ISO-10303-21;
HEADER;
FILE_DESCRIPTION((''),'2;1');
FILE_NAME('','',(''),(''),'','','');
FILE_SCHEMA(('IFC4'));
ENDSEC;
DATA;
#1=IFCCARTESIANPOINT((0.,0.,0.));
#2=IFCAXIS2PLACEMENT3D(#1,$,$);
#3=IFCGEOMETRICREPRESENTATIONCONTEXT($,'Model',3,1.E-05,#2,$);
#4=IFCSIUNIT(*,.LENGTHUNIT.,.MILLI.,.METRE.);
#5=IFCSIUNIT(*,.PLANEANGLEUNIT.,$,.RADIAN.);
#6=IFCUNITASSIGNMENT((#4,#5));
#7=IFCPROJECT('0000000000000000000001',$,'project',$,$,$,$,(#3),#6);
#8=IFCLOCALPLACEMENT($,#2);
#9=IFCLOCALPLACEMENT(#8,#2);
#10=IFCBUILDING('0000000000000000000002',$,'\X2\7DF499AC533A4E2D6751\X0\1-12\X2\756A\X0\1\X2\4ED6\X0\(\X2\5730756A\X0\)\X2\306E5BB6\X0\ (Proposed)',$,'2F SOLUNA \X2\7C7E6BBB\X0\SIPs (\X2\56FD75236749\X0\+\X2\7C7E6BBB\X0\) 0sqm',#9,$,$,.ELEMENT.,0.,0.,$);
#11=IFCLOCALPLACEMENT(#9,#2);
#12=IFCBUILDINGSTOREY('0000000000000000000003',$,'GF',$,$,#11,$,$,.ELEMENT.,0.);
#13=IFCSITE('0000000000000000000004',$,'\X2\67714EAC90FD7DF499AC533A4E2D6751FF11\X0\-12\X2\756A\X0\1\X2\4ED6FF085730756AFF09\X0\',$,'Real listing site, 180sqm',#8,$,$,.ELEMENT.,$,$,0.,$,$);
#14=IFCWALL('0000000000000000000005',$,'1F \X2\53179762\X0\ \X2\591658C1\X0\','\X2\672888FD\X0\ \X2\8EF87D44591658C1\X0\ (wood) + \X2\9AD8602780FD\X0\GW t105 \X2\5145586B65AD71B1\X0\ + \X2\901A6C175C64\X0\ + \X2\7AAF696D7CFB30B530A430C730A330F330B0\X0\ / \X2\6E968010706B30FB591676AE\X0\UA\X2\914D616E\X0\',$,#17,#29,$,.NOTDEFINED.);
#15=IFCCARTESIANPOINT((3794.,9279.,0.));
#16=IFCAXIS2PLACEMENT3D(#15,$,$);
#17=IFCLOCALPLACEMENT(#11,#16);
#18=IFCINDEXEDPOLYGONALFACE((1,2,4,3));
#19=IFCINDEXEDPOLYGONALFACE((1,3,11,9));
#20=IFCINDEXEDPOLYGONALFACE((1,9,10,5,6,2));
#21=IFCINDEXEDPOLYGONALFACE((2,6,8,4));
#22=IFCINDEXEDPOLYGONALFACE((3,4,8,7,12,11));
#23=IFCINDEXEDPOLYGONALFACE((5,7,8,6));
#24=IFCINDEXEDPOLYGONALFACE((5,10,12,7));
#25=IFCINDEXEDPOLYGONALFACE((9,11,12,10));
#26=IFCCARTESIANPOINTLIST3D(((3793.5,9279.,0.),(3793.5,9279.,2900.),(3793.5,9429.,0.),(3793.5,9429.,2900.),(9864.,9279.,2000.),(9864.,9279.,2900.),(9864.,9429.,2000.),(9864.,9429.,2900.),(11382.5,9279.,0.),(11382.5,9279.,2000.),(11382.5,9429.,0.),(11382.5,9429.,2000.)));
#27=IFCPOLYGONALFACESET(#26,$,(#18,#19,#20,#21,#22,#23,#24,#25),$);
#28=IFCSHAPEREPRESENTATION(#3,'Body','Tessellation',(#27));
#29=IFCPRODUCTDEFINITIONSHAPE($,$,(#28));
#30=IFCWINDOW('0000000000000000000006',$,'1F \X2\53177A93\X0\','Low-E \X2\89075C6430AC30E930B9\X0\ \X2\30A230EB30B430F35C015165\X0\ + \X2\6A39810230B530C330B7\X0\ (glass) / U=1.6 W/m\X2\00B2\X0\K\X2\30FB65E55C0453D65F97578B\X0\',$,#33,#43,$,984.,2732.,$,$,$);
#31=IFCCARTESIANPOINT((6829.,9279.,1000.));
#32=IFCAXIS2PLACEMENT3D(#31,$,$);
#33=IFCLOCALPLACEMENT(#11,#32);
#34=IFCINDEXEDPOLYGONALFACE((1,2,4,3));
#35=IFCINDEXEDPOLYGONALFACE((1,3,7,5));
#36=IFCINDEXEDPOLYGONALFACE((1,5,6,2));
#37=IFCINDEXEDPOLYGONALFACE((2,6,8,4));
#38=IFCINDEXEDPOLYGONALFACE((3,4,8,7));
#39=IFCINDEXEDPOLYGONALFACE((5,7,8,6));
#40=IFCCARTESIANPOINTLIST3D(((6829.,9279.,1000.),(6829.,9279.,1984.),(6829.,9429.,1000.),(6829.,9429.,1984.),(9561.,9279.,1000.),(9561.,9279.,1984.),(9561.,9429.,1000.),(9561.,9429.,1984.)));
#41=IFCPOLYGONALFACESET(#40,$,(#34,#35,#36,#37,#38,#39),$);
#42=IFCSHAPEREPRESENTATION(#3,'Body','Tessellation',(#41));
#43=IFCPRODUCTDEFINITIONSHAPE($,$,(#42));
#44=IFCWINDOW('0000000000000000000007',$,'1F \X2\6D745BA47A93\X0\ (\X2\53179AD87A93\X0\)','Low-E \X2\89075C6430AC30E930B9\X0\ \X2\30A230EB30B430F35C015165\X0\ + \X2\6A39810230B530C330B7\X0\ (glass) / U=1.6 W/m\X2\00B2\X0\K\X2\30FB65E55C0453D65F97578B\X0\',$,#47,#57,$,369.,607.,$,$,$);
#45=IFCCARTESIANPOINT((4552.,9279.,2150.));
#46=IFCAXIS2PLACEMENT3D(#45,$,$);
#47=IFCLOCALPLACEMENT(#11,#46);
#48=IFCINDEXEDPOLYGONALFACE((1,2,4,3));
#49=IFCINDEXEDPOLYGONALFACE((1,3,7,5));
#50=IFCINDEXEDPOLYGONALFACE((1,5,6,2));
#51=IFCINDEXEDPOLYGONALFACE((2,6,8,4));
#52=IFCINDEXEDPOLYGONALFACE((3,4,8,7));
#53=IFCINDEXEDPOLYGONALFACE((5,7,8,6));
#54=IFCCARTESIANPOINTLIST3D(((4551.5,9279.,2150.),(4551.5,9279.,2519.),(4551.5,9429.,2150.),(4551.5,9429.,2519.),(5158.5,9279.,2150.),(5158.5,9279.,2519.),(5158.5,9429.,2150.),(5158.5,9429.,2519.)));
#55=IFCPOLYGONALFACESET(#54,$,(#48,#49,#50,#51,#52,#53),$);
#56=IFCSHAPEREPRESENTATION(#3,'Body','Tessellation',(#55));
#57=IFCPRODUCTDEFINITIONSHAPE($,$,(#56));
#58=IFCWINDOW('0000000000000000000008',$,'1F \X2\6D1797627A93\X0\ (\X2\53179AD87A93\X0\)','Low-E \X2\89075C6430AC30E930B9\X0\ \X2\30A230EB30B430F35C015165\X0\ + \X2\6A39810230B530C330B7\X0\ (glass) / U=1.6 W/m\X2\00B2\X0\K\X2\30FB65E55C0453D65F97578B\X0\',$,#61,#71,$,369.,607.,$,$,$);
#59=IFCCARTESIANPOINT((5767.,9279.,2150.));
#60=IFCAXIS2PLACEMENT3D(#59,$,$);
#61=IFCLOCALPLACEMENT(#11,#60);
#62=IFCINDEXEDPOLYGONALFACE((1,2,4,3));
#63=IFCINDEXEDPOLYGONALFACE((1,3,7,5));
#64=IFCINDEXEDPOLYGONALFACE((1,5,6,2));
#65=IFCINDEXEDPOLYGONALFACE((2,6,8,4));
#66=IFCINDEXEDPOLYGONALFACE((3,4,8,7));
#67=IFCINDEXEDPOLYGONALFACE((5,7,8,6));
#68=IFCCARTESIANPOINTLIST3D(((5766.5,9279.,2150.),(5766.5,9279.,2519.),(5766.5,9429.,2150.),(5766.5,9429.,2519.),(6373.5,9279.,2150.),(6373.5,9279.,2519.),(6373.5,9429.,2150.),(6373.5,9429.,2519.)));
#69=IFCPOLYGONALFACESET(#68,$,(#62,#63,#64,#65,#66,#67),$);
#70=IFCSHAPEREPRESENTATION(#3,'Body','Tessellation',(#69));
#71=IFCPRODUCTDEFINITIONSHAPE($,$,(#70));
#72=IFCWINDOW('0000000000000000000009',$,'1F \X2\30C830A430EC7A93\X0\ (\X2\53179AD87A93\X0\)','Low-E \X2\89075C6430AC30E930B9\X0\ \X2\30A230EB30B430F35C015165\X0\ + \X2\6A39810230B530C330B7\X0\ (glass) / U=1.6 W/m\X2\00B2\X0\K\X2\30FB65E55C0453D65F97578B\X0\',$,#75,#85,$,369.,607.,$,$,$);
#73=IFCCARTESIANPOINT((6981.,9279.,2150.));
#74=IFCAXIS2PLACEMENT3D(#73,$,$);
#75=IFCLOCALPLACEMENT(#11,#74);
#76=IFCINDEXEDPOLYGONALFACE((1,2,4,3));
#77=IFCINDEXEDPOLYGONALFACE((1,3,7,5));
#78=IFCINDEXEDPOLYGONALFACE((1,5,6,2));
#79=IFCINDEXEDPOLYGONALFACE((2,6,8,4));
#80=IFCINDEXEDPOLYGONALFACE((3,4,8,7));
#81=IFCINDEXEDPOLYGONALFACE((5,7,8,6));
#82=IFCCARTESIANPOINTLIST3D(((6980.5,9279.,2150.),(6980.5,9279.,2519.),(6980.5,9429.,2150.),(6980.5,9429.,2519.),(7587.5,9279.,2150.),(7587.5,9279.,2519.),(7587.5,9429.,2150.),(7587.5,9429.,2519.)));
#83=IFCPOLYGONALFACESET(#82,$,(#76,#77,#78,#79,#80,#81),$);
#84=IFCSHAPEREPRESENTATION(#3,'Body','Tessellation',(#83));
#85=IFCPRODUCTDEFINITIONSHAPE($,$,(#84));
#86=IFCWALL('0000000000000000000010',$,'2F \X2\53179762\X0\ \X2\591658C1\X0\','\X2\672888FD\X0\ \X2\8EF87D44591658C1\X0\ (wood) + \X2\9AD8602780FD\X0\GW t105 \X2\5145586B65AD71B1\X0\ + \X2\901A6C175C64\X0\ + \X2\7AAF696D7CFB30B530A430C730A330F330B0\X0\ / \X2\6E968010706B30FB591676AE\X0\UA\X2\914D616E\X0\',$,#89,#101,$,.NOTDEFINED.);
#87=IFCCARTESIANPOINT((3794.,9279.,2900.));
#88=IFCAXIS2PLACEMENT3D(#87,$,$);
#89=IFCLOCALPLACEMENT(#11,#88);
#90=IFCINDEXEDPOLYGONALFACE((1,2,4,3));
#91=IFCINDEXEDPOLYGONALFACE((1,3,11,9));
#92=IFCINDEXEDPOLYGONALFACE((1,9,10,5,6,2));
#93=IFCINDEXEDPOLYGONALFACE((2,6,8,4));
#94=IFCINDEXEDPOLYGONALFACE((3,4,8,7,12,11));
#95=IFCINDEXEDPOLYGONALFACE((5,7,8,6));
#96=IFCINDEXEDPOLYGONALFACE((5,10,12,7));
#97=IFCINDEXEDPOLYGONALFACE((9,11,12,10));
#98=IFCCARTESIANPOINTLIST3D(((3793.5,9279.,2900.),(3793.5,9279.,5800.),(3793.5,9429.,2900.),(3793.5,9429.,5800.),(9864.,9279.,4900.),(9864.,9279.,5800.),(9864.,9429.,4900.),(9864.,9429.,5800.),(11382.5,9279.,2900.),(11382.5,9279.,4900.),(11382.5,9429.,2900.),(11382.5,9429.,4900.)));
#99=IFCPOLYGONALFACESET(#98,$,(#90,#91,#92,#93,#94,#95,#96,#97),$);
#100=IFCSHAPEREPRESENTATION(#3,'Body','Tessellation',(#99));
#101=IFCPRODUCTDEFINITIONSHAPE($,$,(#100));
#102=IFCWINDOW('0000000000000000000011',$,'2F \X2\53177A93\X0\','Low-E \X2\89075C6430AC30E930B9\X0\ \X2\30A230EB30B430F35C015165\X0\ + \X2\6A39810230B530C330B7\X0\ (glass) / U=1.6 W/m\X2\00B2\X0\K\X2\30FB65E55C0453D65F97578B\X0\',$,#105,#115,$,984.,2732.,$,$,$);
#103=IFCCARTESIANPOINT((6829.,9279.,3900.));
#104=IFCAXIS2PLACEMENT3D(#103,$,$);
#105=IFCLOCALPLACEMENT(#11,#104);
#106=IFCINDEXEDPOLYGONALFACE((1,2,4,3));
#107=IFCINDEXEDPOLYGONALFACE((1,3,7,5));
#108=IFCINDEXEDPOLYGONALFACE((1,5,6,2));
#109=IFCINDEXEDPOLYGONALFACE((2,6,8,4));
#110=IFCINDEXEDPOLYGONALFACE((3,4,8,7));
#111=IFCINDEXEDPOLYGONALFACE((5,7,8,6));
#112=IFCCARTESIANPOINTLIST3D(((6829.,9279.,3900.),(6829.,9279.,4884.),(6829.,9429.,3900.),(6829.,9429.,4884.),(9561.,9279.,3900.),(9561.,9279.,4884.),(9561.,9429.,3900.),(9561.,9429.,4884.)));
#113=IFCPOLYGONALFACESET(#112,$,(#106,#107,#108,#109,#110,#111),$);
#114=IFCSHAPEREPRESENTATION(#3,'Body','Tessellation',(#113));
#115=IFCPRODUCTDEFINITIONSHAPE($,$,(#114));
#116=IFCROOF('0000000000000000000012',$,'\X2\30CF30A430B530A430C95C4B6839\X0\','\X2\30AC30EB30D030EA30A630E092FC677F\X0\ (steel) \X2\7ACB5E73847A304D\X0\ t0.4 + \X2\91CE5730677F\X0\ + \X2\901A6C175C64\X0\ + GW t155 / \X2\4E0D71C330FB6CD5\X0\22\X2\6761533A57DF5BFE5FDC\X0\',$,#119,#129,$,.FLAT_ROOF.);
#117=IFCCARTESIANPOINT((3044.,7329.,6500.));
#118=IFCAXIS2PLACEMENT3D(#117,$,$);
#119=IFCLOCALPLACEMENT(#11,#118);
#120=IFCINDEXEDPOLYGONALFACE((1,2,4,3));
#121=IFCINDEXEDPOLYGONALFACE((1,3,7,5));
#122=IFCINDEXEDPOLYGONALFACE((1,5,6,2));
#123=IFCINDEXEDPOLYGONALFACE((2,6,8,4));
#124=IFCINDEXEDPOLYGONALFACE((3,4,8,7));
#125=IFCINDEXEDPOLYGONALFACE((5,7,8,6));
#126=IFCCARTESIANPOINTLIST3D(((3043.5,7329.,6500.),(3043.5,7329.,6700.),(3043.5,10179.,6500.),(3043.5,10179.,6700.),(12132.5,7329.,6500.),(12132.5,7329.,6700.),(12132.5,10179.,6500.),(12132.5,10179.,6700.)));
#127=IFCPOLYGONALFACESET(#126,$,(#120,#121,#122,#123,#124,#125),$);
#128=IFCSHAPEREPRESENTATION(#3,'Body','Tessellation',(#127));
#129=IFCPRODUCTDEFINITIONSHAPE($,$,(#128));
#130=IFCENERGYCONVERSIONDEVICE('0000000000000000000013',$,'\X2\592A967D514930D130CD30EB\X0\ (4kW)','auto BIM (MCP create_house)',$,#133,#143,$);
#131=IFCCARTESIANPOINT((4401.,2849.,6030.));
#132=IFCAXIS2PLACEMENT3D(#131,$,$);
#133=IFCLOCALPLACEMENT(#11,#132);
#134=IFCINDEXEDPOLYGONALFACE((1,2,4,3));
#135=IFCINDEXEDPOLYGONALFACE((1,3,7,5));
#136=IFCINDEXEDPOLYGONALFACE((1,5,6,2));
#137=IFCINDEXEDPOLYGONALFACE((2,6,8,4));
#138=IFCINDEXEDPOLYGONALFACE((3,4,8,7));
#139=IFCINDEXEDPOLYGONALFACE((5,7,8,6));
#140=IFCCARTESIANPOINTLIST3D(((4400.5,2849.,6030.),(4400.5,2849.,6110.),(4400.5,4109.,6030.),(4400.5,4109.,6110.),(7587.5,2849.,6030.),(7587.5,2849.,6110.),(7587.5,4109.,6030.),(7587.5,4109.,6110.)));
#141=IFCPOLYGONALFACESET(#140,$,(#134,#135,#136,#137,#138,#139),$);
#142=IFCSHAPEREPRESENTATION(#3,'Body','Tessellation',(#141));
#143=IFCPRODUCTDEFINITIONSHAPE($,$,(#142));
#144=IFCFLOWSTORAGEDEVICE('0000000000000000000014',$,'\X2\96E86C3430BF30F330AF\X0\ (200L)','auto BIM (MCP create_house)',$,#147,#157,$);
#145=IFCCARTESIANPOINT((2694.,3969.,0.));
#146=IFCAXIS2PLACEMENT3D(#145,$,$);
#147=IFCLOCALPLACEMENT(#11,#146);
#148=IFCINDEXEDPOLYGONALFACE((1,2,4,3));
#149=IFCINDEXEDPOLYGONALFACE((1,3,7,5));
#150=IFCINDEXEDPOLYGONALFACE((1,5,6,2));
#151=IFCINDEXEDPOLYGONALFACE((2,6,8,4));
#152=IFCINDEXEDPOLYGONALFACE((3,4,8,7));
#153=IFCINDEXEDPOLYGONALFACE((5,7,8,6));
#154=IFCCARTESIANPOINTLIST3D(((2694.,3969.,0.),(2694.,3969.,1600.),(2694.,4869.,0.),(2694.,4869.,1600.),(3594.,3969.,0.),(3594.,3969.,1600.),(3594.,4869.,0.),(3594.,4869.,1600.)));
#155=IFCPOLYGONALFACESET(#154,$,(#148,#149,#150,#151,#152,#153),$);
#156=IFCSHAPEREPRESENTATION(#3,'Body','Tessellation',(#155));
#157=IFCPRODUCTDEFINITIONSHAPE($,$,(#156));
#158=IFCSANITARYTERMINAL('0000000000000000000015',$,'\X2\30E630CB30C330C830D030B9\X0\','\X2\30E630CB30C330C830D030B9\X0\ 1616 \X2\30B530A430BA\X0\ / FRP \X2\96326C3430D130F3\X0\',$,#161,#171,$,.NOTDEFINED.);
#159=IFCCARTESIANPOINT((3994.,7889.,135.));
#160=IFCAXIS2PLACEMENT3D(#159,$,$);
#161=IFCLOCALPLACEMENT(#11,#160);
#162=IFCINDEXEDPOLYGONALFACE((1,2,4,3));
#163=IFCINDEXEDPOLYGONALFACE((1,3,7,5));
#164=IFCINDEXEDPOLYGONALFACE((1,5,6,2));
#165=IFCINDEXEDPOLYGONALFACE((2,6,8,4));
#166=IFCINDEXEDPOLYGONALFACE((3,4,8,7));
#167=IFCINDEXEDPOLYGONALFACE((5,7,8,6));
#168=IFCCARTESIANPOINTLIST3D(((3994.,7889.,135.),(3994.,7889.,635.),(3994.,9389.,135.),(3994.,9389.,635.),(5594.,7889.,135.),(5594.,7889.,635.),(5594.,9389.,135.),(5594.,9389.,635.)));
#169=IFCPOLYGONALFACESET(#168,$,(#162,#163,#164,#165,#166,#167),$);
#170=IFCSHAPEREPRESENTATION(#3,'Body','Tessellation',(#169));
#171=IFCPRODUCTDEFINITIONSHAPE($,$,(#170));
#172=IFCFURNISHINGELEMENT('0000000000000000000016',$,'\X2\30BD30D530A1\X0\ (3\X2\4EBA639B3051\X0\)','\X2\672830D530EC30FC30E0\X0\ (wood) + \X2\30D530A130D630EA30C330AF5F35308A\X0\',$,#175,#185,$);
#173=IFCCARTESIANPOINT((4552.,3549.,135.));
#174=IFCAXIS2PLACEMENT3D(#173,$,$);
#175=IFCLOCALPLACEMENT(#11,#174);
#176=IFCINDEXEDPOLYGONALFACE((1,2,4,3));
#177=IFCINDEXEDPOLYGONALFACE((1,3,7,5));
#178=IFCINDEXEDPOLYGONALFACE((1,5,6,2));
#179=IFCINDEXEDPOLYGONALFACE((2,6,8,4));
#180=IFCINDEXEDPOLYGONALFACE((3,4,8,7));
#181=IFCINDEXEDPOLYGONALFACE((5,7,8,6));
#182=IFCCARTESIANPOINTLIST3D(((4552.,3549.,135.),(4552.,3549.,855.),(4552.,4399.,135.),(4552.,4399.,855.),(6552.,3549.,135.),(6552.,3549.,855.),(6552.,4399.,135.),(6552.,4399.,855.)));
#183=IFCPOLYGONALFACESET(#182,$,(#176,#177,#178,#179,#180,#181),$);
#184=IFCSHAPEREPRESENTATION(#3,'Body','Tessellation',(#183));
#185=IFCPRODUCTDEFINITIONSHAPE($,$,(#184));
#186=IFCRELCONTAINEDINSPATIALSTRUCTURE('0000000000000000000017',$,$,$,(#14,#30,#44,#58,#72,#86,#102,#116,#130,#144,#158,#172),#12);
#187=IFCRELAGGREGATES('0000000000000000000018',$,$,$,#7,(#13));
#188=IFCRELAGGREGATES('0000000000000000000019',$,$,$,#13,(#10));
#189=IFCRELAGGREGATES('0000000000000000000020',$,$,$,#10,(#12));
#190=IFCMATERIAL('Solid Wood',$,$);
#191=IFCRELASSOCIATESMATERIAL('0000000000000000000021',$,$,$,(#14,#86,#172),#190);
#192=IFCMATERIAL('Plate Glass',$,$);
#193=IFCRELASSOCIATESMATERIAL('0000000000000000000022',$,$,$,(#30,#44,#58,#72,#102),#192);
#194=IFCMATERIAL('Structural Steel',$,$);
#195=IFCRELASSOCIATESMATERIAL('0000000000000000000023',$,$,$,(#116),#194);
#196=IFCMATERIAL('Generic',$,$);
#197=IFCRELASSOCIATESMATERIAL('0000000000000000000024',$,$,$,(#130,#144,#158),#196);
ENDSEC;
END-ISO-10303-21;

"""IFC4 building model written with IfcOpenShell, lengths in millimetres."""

from ifc_helpers import new_model, si_unit, frame, frame_2d, origin, place, context, project, spatial, rectangle, extrude, material, element, fill, save


model = new_model("IFC4")

# Units and contexts
model_context = context("Model", 3, precision=1e-05, world=origin())
ifc_project = project(units=[si_unit("LENGTHUNIT", "METRE", prefix="MILLI"), si_unit("PLANEANGLEUNIT", "RADIAN")], contexts=[model_context])

# Site, building, storey
site_placement = place(None, origin())
site = spatial("IfcSite", under=ifc_project, at=site_placement, Name="東京都練馬区中村１-12番1他（地番）", ObjectType="Real listing site, 180sqm", CompositionType="ELEMENT", RefElevation=0.0)
building_placement = place(site_placement, origin())
building = spatial("IfcBuilding", under=site, at=building_placement, Name="練馬区中村1-12番1他(地番)の家 (Proposed)", ObjectType="2F SOLUNA 籾殻SIPs (国産杉+籾殻) 0sqm", CompositionType="ELEMENT", ElevationOfRefHeight=0.0, ElevationOfTerrain=0.0)
storey_placement = place(building_placement, origin())
storey = spatial("IfcBuildingStorey", under=building, at=storey_placement, Name="GF", CompositionType="ELEMENT", Elevation=0.0)

# Wall, openings, windows
ifc_material_1 = material(Name="Solid Wood")
wall_1_placement = place(storey_placement, frame((3794.0, 9279.0, 0.0)))
wall_1 = element("IfcWall", 1, at=wall_1_placement, inside=storey, material=ifc_material_1, Name="1F 北面 外壁", Description="木製 軸組外壁 (wood) + 高性能GW t105 充填断熱 + 通気層 + 窯業系サイディング / 準耐火・外皮UA配慮", PredefinedType="NOTDEFINED", context=model_context, shape_type="SweptSolid", body=[
    extrude(rectangle(XDim=7589.0, YDim=150.0, at=frame_2d((3794.0, 75.0))), frame((3794.0, 9279.0, 0.0)), (0.0, 0.0, 1.0), 2900.0),
])
opening_1_placement = place(storey_placement, frame((6829.0, 9279.0, 1000.0)))
opening_1 = element("IfcOpeningElement", 2, at=opening_1_placement, cuts=wall_1, PredefinedType="NOTDEFINED", context=model_context, shape_type="SweptSolid", body=[
    extrude(rectangle(XDim=2732.0, YDim=150.0, at=frame_2d((1366.0, 75.0))), frame((6829.0, 9279.0, 1000.0)), (0.0, 0.0, 1.0), 984.0),
])
opening_2_placement = place(storey_placement, frame((4552.0, 9279.0, 2150.0)))
opening_2 = element("IfcOpeningElement", 3, at=opening_2_placement, cuts=wall_1, PredefinedType="NOTDEFINED", context=model_context, shape_type="SweptSolid", body=[
    extrude(rectangle(XDim=607.0, YDim=150.0, at=frame_2d((303.0, 75.0))), frame((4552.0, 9279.0, 2150.0)), (0.0, 0.0, 1.0), 369.0),
])
opening_3_placement = place(storey_placement, frame((5767.0, 9279.0, 2150.0)))
opening_3 = element("IfcOpeningElement", 4, at=opening_3_placement, cuts=wall_1, PredefinedType="NOTDEFINED", context=model_context, shape_type="SweptSolid", body=[
    extrude(rectangle(XDim=607.0, YDim=150.0, at=frame_2d((303.0, 75.0))), frame((5767.0, 9279.0, 2150.0)), (0.0, 0.0, 1.0), 369.0),
])
opening_4_placement = place(storey_placement, frame((6981.0, 9279.0, 2150.0)))
opening_4 = element("IfcOpeningElement", 5, at=opening_4_placement, cuts=wall_1, PredefinedType="NOTDEFINED", context=model_context, shape_type="SweptSolid", body=[
    extrude(rectangle(XDim=607.0, YDim=150.0, at=frame_2d((303.0, 75.0))), frame((6981.0, 9279.0, 2150.0)), (0.0, 0.0, 1.0), 369.0),
])
ifc_material_2 = material(Name="Plate Glass")
window_1_placement = place(storey_placement, frame((6829.0, 9279.0, 1000.0)))
window_1 = element("IfcWindow", 6, at=window_1_placement, inside=storey, material=ifc_material_2, Name="1F 北窓", Description="Low-E 複層ガラス アルゴン封入 + 樹脂サッシ (glass) / U=1.6 W/m²K・日射取得型", OverallHeight=984.0, OverallWidth=2732.0, context=model_context, shape_type="SweptSolid", body=[
    extrude(rectangle(XDim=2732.0, YDim=150.0, at=frame_2d((1366.0, 75.0))), frame((6829.0, 9279.0, 1000.0)), (0.0, 0.0, 1.0), 984.0),
])
fill(opening_1, window_1)
window_2_placement = place(storey_placement, frame((4552.0, 9279.0, 2150.0)))
window_2 = element("IfcWindow", 7, at=window_2_placement, inside=storey, material=ifc_material_2, Name="1F 浴室窓 (北高窓)", Description="Low-E 複層ガラス アルゴン封入 + 樹脂サッシ (glass) / U=1.6 W/m²K・日射取得型", OverallHeight=369.0, OverallWidth=607.0, context=model_context, shape_type="SweptSolid", body=[
    extrude(rectangle(XDim=607.0, YDim=150.0, at=frame_2d((303.0, 75.0))), frame((4552.0, 9279.0, 2150.0)), (0.0, 0.0, 1.0), 369.0),
])
fill(opening_2, window_2)
window_3_placement = place(storey_placement, frame((5767.0, 9279.0, 2150.0)))
window_3 = element("IfcWindow", 8, at=window_3_placement, inside=storey, material=ifc_material_2, Name="1F 洗面窓 (北高窓)", Description="Low-E 複層ガラス アルゴン封入 + 樹脂サッシ (glass) / U=1.6 W/m²K・日射取得型", OverallHeight=369.0, OverallWidth=607.0, context=model_context, shape_type="SweptSolid", body=[
    extrude(rectangle(XDim=607.0, YDim=150.0, at=frame_2d((303.0, 75.0))), frame((5767.0, 9279.0, 2150.0)), (0.0, 0.0, 1.0), 369.0),
])
fill(opening_3, window_3)
window_4_placement = place(storey_placement, frame((6981.0, 9279.0, 2150.0)))
window_4 = element("IfcWindow", 9, at=window_4_placement, inside=storey, material=ifc_material_2, Name="1F トイレ窓 (北高窓)", Description="Low-E 複層ガラス アルゴン封入 + 樹脂サッシ (glass) / U=1.6 W/m²K・日射取得型", OverallHeight=369.0, OverallWidth=607.0, context=model_context, shape_type="SweptSolid", body=[
    extrude(rectangle(XDim=607.0, YDim=150.0, at=frame_2d((303.0, 75.0))), frame((6981.0, 9279.0, 2150.0)), (0.0, 0.0, 1.0), 369.0),
])
fill(opening_4, window_4)

# Wall, opening, window
wall_2_placement = place(storey_placement, frame((3794.0, 9279.0, 2900.0)))
wall_2 = element("IfcWall", 10, at=wall_2_placement, inside=storey, material=ifc_material_1, Name="2F 北面 外壁", Description="木製 軸組外壁 (wood) + 高性能GW t105 充填断熱 + 通気層 + 窯業系サイディング / 準耐火・外皮UA配慮", PredefinedType="NOTDEFINED", context=model_context, shape_type="SweptSolid", body=[
    extrude(rectangle(XDim=7589.0, YDim=150.0, at=frame_2d((3794.0, 75.0))), frame((3794.0, 9279.0, 2900.0)), (0.0, 0.0, 1.0), 2900.0),
])
opening_5_placement = place(storey_placement, frame((6829.0, 9279.0, 3900.0)))
opening_5 = element("IfcOpeningElement", 11, at=opening_5_placement, cuts=wall_2, PredefinedType="NOTDEFINED", context=model_context, shape_type="SweptSolid", body=[
    extrude(rectangle(XDim=2732.0, YDim=150.0, at=frame_2d((1366.0, 75.0))), frame((6829.0, 9279.0, 3900.0)), (0.0, 0.0, 1.0), 984.0),
])
window_5_placement = place(storey_placement, frame((6829.0, 9279.0, 3900.0)))
window_5 = element("IfcWindow", 12, at=window_5_placement, inside=storey, material=ifc_material_2, Name="2F 北窓", Description="Low-E 複層ガラス アルゴン封入 + 樹脂サッシ (glass) / U=1.6 W/m²K・日射取得型", OverallHeight=984.0, OverallWidth=2732.0, context=model_context, shape_type="SweptSolid", body=[
    extrude(rectangle(XDim=2732.0, YDim=150.0, at=frame_2d((1366.0, 75.0))), frame((6829.0, 9279.0, 3900.0)), (0.0, 0.0, 1.0), 984.0),
])
fill(opening_5, window_5)

# Roof
ifc_material_3 = material(Name="Structural Steel")
roof_placement = place(storey_placement, frame((3044.0, 7329.0, 6500.0)))
element("IfcRoof", 13, at=roof_placement, inside=storey, material=ifc_material_3, Name="ハイサイド屋根", Description="ガルバリウム鋼板 (steel) 立平葺き t0.4 + 野地板 + 通気層 + GW t155 / 不燃・法22条区域対応", PredefinedType="FLAT_ROOF", context=model_context, shape_type="SweptSolid", body=[
    extrude(rectangle(XDim=9089.0, YDim=2850.0, at=frame_2d((4544.0, 1425.0))), frame((3044.0, 7329.0, 6500.0)), (0.0, 0.0, 1.0), 200.0),
])

# Energy conversion device
ifc_material_4 = material(Name="Generic")
energy_conversion_device_placement = place(storey_placement, frame((4401.0, 2849.0, 6030.0)))
element("IfcEnergyConversionDevice", 14, at=energy_conversion_device_placement, inside=storey, material=ifc_material_4, Name="太陽光パネル (4kW)", Description="auto BIM (MCP create_house)", context=model_context, shape_type="SweptSolid", body=[
    extrude(rectangle(XDim=3187.0, YDim=1260.0, at=frame_2d((1593.0, 630.0))), frame((4401.0, 2849.0, 6030.0)), (0.0, 0.0, 1.0), 80.0),
])

# Flow storage device
flow_storage_device_placement = place(storey_placement, frame((2694.0, 3969.0, 0.0)))
element("IfcFlowStorageDevice", 15, at=flow_storage_device_placement, inside=storey, material=ifc_material_4, Name="雨水タンク (200L)", Description="auto BIM (MCP create_house)", context=model_context, shape_type="SweptSolid", body=[
    extrude(rectangle(XDim=900.0, YDim=900.0, at=frame_2d((450.0, 450.0))), frame((2694.0, 3969.0, 0.0)), (0.0, 0.0, 1.0), 1600.0),
])

# Sanitary terminal
sanitary_terminal_placement = place(storey_placement, frame((3994.0, 7889.0, 135.0)))
element("IfcSanitaryTerminal", 16, at=sanitary_terminal_placement, inside=storey, material=ifc_material_4, Name="ユニットバス", Description="ユニットバス 1616 サイズ / FRP 防水パン", PredefinedType="NOTDEFINED", context=model_context, shape_type="SweptSolid", body=[
    extrude(rectangle(XDim=1600.0, YDim=1500.0, at=frame_2d((800.0, 750.0))), frame((3994.0, 7889.0, 135.0)), (0.0, 0.0, 1.0), 500.0),
])

# Furnishing element
furnishing_1_placement = place(storey_placement, frame((4552.0, 3549.0, 135.0)))
element("IfcFurnishingElement", 17, at=furnishing_1_placement, inside=storey, material=ifc_material_1, Name="ソファ (3人掛け)", Description="木フレーム (wood) + ファブリック張り", context=model_context, shape_type="SweptSolid", body=[
    extrude(rectangle(XDim=2000.0, YDim=850.0, at=frame_2d((1000.0, 425.0))), frame((4552.0, 3549.0, 135.0)), (0.0, 0.0, 1.0), 720.0),
])

save(model, "model.ifc")
